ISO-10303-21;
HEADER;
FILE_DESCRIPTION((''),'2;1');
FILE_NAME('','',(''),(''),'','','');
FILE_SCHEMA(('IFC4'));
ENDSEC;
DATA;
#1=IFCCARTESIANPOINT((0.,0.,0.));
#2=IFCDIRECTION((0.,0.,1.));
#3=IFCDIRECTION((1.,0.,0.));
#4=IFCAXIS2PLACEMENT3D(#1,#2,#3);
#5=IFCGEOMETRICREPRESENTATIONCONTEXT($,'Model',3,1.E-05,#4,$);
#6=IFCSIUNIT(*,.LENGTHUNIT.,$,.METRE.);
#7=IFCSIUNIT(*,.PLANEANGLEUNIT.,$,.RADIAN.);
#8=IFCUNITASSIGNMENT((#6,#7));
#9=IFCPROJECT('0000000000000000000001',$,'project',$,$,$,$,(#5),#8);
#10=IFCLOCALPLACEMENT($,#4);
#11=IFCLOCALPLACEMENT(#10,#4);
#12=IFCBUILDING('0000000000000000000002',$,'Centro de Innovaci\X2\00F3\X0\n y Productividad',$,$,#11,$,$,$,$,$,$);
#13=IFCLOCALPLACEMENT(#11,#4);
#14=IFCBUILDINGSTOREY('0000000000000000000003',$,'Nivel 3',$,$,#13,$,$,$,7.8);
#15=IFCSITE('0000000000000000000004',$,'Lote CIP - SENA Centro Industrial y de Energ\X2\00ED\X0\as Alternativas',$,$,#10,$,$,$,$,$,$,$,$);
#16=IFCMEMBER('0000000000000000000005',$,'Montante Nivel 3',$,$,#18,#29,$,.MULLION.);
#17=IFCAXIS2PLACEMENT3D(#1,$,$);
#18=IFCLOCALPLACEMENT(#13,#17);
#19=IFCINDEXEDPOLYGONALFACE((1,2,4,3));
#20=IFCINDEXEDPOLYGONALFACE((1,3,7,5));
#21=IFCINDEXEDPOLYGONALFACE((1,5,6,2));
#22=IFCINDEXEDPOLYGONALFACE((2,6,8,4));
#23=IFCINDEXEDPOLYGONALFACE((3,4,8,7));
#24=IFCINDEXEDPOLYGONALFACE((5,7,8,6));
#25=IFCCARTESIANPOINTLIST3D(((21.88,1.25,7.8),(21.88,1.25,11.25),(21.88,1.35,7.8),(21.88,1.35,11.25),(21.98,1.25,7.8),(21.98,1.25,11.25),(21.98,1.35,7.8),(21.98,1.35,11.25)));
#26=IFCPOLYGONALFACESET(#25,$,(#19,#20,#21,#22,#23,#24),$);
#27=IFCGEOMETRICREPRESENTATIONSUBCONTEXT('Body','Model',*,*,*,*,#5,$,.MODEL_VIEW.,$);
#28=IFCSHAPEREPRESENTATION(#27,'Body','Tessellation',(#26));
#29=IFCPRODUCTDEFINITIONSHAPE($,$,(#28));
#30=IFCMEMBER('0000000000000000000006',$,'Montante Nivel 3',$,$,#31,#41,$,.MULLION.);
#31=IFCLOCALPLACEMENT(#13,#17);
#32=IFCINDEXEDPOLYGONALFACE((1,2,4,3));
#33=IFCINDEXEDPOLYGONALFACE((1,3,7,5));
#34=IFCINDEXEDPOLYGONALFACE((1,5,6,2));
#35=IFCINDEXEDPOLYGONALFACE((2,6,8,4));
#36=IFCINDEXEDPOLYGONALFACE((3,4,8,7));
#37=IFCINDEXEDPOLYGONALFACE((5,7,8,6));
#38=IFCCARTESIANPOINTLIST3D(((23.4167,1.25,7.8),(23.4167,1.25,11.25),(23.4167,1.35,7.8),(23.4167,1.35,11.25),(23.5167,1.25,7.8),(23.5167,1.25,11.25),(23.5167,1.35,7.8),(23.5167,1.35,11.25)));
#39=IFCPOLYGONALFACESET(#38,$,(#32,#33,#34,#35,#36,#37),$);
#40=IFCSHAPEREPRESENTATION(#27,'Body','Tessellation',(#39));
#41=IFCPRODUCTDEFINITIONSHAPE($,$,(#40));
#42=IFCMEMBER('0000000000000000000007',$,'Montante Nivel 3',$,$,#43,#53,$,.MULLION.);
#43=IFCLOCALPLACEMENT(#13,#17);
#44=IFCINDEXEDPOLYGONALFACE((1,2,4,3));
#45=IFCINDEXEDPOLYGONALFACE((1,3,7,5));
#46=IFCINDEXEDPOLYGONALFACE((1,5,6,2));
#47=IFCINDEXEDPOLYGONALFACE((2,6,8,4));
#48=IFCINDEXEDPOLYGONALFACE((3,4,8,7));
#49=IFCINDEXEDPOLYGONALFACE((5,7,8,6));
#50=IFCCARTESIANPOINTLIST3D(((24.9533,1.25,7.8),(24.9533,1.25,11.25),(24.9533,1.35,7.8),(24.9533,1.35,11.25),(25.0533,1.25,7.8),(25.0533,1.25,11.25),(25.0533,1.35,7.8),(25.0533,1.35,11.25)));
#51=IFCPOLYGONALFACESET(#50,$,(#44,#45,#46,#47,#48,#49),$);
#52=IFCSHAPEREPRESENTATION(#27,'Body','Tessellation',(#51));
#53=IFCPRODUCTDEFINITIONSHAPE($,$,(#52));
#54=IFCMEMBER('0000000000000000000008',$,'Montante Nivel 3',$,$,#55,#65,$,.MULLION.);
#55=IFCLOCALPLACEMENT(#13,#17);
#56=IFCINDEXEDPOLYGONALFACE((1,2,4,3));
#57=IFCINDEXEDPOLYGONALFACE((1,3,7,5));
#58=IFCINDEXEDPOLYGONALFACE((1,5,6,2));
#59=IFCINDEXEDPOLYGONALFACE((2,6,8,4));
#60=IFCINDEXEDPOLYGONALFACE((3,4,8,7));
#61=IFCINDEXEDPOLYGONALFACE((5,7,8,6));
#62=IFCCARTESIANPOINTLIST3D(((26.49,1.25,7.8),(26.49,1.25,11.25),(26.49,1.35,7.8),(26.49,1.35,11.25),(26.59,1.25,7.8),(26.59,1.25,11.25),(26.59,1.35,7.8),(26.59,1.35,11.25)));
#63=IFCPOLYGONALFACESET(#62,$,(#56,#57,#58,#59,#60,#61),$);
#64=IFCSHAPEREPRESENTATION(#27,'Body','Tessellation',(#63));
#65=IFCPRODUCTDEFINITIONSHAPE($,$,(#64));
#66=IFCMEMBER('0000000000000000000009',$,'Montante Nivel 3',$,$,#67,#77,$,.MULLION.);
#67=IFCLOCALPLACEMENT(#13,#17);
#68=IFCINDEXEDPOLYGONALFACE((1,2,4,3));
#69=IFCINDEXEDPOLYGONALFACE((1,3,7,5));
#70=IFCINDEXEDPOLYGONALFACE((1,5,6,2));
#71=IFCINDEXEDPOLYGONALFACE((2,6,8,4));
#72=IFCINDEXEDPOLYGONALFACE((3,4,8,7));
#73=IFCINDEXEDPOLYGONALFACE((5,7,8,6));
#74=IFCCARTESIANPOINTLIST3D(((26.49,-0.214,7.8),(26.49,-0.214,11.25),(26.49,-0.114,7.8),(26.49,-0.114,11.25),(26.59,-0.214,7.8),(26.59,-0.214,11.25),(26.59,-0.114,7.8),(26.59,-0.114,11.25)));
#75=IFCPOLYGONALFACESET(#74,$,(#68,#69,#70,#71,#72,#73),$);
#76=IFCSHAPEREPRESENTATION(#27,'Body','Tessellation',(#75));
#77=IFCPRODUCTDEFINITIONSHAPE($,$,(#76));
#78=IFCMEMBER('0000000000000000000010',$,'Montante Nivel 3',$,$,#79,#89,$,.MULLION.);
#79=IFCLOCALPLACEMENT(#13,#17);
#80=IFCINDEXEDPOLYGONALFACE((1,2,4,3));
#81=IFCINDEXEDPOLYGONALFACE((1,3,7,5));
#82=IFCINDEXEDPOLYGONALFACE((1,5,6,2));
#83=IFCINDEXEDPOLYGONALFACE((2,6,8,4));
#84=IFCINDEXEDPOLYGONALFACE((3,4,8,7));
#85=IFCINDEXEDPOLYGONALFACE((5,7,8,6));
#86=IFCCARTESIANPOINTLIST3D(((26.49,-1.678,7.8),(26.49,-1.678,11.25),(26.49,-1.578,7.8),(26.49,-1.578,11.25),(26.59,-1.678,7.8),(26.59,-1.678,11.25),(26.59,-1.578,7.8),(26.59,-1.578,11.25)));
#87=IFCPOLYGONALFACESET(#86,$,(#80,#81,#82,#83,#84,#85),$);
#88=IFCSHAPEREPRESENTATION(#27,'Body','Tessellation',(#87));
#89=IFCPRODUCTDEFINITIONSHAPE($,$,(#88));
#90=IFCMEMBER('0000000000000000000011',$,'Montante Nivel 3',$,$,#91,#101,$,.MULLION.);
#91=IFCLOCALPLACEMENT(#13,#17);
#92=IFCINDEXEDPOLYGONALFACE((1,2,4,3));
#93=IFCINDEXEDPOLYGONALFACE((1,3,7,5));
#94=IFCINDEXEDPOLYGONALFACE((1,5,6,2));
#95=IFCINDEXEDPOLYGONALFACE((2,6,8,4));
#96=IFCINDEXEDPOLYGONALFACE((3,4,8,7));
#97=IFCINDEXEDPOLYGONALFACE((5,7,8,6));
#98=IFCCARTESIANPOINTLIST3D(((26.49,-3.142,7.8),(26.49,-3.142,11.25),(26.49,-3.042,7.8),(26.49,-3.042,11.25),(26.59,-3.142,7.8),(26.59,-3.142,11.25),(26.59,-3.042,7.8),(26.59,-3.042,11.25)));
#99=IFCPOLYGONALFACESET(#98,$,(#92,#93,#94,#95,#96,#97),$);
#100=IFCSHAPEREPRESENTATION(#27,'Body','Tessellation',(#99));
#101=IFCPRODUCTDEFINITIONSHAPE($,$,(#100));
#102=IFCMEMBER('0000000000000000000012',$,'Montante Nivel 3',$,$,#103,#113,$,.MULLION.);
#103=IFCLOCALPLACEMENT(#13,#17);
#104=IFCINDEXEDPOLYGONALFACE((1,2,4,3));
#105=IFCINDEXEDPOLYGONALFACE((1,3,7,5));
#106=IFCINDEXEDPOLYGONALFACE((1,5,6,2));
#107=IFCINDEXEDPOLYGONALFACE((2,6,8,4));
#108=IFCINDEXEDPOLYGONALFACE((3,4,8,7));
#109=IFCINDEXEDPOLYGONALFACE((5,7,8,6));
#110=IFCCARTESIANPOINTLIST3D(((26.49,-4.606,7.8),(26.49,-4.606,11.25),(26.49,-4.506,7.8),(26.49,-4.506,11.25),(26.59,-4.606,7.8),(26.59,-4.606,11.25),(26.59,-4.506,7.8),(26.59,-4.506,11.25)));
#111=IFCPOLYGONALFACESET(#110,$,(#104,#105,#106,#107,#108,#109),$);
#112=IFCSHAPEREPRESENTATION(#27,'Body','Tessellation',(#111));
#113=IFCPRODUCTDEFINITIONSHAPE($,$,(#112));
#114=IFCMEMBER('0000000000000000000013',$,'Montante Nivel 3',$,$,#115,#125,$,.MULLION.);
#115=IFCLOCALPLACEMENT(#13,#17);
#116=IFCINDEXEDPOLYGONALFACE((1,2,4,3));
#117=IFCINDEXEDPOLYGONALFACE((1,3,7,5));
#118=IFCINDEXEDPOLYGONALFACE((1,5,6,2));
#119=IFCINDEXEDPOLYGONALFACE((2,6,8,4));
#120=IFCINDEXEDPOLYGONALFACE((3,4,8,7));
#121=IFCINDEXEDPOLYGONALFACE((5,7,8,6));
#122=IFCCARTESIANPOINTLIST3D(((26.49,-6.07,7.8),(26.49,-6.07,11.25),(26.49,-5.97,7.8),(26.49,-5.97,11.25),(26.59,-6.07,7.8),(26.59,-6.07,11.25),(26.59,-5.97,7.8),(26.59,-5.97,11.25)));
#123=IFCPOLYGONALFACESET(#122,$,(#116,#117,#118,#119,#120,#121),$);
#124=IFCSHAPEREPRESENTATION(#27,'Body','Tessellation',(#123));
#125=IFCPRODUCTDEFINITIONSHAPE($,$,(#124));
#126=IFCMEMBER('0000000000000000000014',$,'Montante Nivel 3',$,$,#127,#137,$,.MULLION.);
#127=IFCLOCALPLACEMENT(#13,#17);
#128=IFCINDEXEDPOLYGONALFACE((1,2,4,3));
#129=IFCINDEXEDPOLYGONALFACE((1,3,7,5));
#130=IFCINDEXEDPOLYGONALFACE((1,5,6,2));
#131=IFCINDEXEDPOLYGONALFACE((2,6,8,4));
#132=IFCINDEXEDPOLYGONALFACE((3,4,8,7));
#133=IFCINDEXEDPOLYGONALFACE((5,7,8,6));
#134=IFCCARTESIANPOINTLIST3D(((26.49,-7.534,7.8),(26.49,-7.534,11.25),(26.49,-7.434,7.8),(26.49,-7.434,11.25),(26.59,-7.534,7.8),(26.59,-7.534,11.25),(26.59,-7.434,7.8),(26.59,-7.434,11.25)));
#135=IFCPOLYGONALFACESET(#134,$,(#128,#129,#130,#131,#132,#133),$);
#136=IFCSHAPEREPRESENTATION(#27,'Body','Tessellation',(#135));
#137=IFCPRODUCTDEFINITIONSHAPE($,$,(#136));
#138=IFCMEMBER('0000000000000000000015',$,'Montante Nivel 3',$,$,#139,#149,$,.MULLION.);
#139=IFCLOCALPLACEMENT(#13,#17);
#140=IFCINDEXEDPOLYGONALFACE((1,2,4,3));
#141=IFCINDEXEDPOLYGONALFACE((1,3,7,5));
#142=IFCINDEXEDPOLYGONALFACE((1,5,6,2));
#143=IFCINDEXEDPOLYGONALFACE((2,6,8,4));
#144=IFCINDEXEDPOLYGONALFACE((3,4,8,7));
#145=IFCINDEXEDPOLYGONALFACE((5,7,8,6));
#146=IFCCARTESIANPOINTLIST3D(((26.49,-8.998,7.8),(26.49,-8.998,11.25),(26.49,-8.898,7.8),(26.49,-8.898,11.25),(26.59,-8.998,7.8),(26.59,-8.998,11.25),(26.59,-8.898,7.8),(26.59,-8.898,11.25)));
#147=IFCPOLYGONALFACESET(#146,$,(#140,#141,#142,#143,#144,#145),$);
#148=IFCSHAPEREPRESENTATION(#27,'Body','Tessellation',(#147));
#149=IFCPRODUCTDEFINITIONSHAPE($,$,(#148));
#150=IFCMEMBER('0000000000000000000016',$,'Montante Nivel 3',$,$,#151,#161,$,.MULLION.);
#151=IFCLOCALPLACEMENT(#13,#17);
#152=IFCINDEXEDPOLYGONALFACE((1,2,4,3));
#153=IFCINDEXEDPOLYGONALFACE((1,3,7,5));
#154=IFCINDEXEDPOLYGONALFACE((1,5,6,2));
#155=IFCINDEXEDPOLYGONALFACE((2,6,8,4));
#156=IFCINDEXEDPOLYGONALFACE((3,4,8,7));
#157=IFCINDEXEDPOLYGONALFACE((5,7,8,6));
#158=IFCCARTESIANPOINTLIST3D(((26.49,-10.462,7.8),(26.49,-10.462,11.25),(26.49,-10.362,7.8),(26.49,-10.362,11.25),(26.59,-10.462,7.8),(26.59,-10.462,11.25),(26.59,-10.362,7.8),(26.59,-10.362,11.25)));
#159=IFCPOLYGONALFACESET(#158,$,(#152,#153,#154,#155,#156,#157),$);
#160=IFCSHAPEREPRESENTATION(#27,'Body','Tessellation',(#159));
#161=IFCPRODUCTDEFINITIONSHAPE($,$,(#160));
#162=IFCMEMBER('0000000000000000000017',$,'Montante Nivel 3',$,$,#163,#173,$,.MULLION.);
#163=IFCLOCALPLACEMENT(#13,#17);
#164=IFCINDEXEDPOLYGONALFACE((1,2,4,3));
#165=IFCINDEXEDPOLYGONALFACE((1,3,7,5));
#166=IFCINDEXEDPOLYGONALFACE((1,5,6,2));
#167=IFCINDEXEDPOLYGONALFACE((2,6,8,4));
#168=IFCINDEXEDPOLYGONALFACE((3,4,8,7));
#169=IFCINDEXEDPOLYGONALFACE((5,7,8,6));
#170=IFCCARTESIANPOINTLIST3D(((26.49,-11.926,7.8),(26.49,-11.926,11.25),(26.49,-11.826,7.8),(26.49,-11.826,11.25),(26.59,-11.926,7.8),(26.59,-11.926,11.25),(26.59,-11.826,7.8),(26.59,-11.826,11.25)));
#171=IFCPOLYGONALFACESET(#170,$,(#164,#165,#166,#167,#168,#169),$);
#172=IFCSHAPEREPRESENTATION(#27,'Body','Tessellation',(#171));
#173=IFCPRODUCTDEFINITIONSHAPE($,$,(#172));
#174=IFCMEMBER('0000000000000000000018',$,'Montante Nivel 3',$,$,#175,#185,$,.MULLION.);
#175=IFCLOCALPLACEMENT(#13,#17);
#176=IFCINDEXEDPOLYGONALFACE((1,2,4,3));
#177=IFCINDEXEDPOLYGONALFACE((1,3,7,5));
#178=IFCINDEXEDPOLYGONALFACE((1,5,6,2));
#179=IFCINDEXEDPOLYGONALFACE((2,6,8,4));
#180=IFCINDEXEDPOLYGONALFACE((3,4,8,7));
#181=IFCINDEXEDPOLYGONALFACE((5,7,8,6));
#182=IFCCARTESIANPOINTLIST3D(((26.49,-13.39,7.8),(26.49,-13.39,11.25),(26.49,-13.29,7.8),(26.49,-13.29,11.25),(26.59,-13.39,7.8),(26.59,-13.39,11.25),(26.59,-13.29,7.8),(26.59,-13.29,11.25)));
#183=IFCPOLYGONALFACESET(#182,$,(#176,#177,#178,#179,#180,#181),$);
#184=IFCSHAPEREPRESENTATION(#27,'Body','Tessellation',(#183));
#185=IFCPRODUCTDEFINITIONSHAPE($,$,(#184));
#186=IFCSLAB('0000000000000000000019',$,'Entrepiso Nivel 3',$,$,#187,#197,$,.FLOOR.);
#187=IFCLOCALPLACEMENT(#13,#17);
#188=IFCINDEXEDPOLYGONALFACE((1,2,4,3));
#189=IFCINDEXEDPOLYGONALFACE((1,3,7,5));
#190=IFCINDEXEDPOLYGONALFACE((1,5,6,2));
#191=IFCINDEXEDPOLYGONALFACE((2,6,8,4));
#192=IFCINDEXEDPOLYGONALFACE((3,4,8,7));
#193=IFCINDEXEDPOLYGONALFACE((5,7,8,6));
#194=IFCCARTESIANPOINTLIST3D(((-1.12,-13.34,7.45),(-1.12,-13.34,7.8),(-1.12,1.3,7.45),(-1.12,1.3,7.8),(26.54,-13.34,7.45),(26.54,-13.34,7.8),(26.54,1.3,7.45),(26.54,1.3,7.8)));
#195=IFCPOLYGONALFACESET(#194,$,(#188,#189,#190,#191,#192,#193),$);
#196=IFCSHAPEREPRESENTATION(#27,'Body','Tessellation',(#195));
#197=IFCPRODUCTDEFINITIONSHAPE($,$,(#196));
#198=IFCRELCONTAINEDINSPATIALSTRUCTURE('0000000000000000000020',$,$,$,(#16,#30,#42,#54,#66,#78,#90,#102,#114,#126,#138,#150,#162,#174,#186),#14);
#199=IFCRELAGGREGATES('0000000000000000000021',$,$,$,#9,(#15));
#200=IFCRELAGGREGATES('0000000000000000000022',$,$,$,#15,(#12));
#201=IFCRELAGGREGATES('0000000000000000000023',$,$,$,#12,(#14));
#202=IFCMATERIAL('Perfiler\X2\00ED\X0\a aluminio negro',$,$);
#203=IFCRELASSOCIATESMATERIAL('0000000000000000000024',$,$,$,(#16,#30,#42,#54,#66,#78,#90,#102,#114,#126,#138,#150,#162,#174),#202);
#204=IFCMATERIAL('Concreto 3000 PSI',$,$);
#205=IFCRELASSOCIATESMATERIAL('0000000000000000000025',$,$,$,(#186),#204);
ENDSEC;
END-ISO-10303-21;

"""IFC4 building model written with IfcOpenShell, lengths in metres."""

from ifc_helpers import new_model, si_unit, frame, origin_with_axes, place, context, subcontext, project, spatial, polyline, outline, extrude, material, element, save


model = new_model("IFC4")

# Units and contexts
model_context = context("Model", 3, precision=1e-05, world=origin_with_axes())
body_context = subcontext(model_context, "Body", "Model", "MODEL_VIEW")
ifc_project = project(units=[si_unit("LENGTHUNIT", "METRE"), si_unit("PLANEANGLEUNIT", "RADIAN")], contexts=[model_context])

# Site, building, storey
site_placement = place(None, origin_with_axes())
site = spatial("IfcSite", under=ifc_project, at=site_placement, Name="Lote CIP - SENA Centro Industrial y de Energías Alternativas")
building_placement = place(site_placement, origin_with_axes())
building = spatial("IfcBuilding", under=site, at=building_placement, Name="Centro de Innovación y Productividad")
storey_placement = place(building_placement, origin_with_axes())
storey = spatial("IfcBuildingStorey", under=building, at=storey_placement, Name="Nivel 3", Elevation=7.8)

# Members
ifc_material_1 = material(Name="Perfilería aluminio negro")
member_1_placement = place(storey_placement, origin_with_axes())
element("IfcMember", 1, at=member_1_placement, inside=storey, material=ifc_material_1, Name="Montante Nivel 3", PredefinedType="MULLION", context=body_context, shape_type="SweptSolid", body=[
    extrude(outline(polyline([(21.98, 1.35), (21.98, 1.25), (21.88, 1.25), (21.88, 1.35), (21.98, 1.35)])), frame((0.0, 0.0, 7.8)), (0.0, 0.0, 1.0), 3.45),
])
member_2_placement = place(storey_placement, origin_with_axes())
element("IfcMember", 2, at=member_2_placement, inside=storey, material=ifc_material_1, Name="Montante Nivel 3", PredefinedType="MULLION", context=body_context, shape_type="SweptSolid", body=[
    extrude(outline(polyline([(23.5167, 1.35), (23.5167, 1.25), (23.4167, 1.25), (23.4167, 1.35), (23.5167, 1.35)])), frame((0.0, 0.0, 7.8)), (0.0, 0.0, 1.0), 3.45),
])
member_3_placement = place(storey_placement, origin_with_axes())
element("IfcMember", 3, at=member_3_placement, inside=storey, material=ifc_material_1, Name="Montante Nivel 3", PredefinedType="MULLION", context=body_context, shape_type="SweptSolid", body=[
    extrude(outline(polyline([(25.0533, 1.35), (25.0533, 1.25), (24.9533, 1.25), (24.9533, 1.35), (25.0533, 1.35)])), frame((0.0, 0.0, 7.8)), (0.0, 0.0, 1.0), 3.45),
])
for number, where, z_axis, x_axis, name in (
    (4, (0.0, 0.0, 0.0), (0.0, 0.0, 1.0), (1.0, 0.0, 0.0), "Montante Nivel 3"),
):
    element("IfcMember", number, at=place(storey_placement, frame(where, z_axis=z_axis, x_axis=x_axis)), inside=storey, material=ifc_material_1, Name=name, PredefinedType="MULLION", context=body_context, shape_type="SweptSolid", body=[
        extrude(outline(polyline([(26.59, 1.35), (26.59, 1.25), (26.49, 1.25), (26.49, 1.35), (26.59, 1.35)])), frame((0.0, 0.0, 7.8)), (0.0, 0.0, 1.0), 3.45),
    ])
member_4_placement = place(storey_placement, origin_with_axes())
element("IfcMember", 5, at=member_4_placement, inside=storey, material=ifc_material_1, Name="Montante Nivel 3", PredefinedType="MULLION", context=body_context, shape_type="SweptSolid", body=[
    extrude(outline(polyline([(26.59, -0.114), (26.59, -0.214), (26.49, -0.214), (26.49, -0.114), (26.59, -0.114)])), frame((0.0, 0.0, 7.8)), (0.0, 0.0, 1.0), 3.45),
])
member_5_placement = place(storey_placement, origin_with_axes())
element("IfcMember", 6, at=member_5_placement, inside=storey, material=ifc_material_1, Name="Montante Nivel 3", PredefinedType="MULLION", context=body_context, shape_type="SweptSolid", body=[
    extrude(outline(polyline([(26.59, -1.578), (26.59, -1.678), (26.49, -1.678), (26.49, -1.578), (26.59, -1.578)])), frame((0.0, 0.0, 7.8)), (0.0, 0.0, 1.0), 3.45),
])
member_6_placement = place(storey_placement, origin_with_axes())
element("IfcMember", 7, at=member_6_placement, inside=storey, material=ifc_material_1, Name="Montante Nivel 3", PredefinedType="MULLION", context=body_context, shape_type="SweptSolid", body=[
    extrude(outline(polyline([(26.59, -3.042), (26.59, -3.142), (26.49, -3.142), (26.49, -3.042), (26.59, -3.042)])), frame((0.0, 0.0, 7.8)), (0.0, 0.0, 1.0), 3.45),
])
member_7_placement = place(storey_placement, origin_with_axes())
element("IfcMember", 8, at=member_7_placement, inside=storey, material=ifc_material_1, Name="Montante Nivel 3", PredefinedType="MULLION", context=body_context, shape_type="SweptSolid", body=[
    extrude(outline(polyline([(26.59, -4.506), (26.59, -4.606), (26.49, -4.606), (26.49, -4.506), (26.59, -4.506)])), frame((0.0, 0.0, 7.8)), (0.0, 0.0, 1.0), 3.45),
])
member_8_placement = place(storey_placement, origin_with_axes())
element("IfcMember", 9, at=member_8_placement, inside=storey, material=ifc_material_1, Name="Montante Nivel 3", PredefinedType="MULLION", context=body_context, shape_type="SweptSolid", body=[
    extrude(outline(polyline([(26.59, -5.97), (26.59, -6.07), (26.49, -6.07), (26.49, -5.97), (26.59, -5.97)])), frame((0.0, 0.0, 7.8)), (0.0, 0.0, 1.0), 3.45),
])
member_9_placement = place(storey_placement, origin_with_axes())
element("IfcMember", 10, at=member_9_placement, inside=storey, material=ifc_material_1, Name="Montante Nivel 3", PredefinedType="MULLION", context=body_context, shape_type="SweptSolid", body=[
    extrude(outline(polyline([(26.59, -7.434), (26.59, -7.534), (26.49, -7.534), (26.49, -7.434), (26.59, -7.434)])), frame((0.0, 0.0, 7.8)), (0.0, 0.0, 1.0), 3.45),
])
member_10_placement = place(storey_placement, origin_with_axes())
element("IfcMember", 11, at=member_10_placement, inside=storey, material=ifc_material_1, Name="Montante Nivel 3", PredefinedType="MULLION", context=body_context, shape_type="SweptSolid", body=[
    extrude(outline(polyline([(26.59, -8.898), (26.59, -8.998), (26.49, -8.998), (26.49, -8.898), (26.59, -8.898)])), frame((0.0, 0.0, 7.8)), (0.0, 0.0, 1.0), 3.45),
])
member_11_placement = place(storey_placement, origin_with_axes())
element("IfcMember", 12, at=member_11_placement, inside=storey, material=ifc_material_1, Name="Montante Nivel 3", PredefinedType="MULLION", context=body_context, shape_type="SweptSolid", body=[
    extrude(outline(polyline([(26.59, -10.362), (26.59, -10.462), (26.49, -10.462), (26.49, -10.362), (26.59, -10.362)])), frame((0.0, 0.0, 7.8)), (0.0, 0.0, 1.0), 3.45),
])
member_12_placement = place(storey_placement, origin_with_axes())
element("IfcMember", 13, at=member_12_placement, inside=storey, material=ifc_material_1, Name="Montante Nivel 3", PredefinedType="MULLION", context=body_context, shape_type="SweptSolid", body=[
    extrude(outline(polyline([(26.59, -11.826), (26.59, -11.926), (26.49, -11.926), (26.49, -11.826), (26.59, -11.826)])), frame((0.0, 0.0, 7.8)), (0.0, 0.0, 1.0), 3.45),
])
member_13_placement = place(storey_placement, origin_with_axes())
element("IfcMember", 14, at=member_13_placement, inside=storey, material=ifc_material_1, Name="Montante Nivel 3", PredefinedType="MULLION", context=body_context, shape_type="SweptSolid", body=[
    extrude(outline(polyline([(26.59, -13.29), (26.59, -13.39), (26.49, -13.39), (26.49, -13.29), (26.59, -13.29)])), frame((0.0, 0.0, 7.8)), (0.0, 0.0, 1.0), 3.45),
])

# Slab
ifc_material_2 = material(Name="Concreto 3000 PSI")
slab_1_placement = place(storey_placement, origin_with_axes())
element("IfcSlab", 15, at=slab_1_placement, inside=storey, material=ifc_material_2, Name="Entrepiso Nivel 3", PredefinedType="FLOOR", context=body_context, shape_type="SweptSolid", body=[
    extrude(outline(polyline([(-1.12, 1.3), (26.54, 1.3), (26.54, -13.34), (-1.12, -13.34), (-1.12, 1.3)])), frame((0.0, 0.0, 7.45)), (0.0, 0.0, 1.0), 0.35),
])

save(model, "model.ifc")
